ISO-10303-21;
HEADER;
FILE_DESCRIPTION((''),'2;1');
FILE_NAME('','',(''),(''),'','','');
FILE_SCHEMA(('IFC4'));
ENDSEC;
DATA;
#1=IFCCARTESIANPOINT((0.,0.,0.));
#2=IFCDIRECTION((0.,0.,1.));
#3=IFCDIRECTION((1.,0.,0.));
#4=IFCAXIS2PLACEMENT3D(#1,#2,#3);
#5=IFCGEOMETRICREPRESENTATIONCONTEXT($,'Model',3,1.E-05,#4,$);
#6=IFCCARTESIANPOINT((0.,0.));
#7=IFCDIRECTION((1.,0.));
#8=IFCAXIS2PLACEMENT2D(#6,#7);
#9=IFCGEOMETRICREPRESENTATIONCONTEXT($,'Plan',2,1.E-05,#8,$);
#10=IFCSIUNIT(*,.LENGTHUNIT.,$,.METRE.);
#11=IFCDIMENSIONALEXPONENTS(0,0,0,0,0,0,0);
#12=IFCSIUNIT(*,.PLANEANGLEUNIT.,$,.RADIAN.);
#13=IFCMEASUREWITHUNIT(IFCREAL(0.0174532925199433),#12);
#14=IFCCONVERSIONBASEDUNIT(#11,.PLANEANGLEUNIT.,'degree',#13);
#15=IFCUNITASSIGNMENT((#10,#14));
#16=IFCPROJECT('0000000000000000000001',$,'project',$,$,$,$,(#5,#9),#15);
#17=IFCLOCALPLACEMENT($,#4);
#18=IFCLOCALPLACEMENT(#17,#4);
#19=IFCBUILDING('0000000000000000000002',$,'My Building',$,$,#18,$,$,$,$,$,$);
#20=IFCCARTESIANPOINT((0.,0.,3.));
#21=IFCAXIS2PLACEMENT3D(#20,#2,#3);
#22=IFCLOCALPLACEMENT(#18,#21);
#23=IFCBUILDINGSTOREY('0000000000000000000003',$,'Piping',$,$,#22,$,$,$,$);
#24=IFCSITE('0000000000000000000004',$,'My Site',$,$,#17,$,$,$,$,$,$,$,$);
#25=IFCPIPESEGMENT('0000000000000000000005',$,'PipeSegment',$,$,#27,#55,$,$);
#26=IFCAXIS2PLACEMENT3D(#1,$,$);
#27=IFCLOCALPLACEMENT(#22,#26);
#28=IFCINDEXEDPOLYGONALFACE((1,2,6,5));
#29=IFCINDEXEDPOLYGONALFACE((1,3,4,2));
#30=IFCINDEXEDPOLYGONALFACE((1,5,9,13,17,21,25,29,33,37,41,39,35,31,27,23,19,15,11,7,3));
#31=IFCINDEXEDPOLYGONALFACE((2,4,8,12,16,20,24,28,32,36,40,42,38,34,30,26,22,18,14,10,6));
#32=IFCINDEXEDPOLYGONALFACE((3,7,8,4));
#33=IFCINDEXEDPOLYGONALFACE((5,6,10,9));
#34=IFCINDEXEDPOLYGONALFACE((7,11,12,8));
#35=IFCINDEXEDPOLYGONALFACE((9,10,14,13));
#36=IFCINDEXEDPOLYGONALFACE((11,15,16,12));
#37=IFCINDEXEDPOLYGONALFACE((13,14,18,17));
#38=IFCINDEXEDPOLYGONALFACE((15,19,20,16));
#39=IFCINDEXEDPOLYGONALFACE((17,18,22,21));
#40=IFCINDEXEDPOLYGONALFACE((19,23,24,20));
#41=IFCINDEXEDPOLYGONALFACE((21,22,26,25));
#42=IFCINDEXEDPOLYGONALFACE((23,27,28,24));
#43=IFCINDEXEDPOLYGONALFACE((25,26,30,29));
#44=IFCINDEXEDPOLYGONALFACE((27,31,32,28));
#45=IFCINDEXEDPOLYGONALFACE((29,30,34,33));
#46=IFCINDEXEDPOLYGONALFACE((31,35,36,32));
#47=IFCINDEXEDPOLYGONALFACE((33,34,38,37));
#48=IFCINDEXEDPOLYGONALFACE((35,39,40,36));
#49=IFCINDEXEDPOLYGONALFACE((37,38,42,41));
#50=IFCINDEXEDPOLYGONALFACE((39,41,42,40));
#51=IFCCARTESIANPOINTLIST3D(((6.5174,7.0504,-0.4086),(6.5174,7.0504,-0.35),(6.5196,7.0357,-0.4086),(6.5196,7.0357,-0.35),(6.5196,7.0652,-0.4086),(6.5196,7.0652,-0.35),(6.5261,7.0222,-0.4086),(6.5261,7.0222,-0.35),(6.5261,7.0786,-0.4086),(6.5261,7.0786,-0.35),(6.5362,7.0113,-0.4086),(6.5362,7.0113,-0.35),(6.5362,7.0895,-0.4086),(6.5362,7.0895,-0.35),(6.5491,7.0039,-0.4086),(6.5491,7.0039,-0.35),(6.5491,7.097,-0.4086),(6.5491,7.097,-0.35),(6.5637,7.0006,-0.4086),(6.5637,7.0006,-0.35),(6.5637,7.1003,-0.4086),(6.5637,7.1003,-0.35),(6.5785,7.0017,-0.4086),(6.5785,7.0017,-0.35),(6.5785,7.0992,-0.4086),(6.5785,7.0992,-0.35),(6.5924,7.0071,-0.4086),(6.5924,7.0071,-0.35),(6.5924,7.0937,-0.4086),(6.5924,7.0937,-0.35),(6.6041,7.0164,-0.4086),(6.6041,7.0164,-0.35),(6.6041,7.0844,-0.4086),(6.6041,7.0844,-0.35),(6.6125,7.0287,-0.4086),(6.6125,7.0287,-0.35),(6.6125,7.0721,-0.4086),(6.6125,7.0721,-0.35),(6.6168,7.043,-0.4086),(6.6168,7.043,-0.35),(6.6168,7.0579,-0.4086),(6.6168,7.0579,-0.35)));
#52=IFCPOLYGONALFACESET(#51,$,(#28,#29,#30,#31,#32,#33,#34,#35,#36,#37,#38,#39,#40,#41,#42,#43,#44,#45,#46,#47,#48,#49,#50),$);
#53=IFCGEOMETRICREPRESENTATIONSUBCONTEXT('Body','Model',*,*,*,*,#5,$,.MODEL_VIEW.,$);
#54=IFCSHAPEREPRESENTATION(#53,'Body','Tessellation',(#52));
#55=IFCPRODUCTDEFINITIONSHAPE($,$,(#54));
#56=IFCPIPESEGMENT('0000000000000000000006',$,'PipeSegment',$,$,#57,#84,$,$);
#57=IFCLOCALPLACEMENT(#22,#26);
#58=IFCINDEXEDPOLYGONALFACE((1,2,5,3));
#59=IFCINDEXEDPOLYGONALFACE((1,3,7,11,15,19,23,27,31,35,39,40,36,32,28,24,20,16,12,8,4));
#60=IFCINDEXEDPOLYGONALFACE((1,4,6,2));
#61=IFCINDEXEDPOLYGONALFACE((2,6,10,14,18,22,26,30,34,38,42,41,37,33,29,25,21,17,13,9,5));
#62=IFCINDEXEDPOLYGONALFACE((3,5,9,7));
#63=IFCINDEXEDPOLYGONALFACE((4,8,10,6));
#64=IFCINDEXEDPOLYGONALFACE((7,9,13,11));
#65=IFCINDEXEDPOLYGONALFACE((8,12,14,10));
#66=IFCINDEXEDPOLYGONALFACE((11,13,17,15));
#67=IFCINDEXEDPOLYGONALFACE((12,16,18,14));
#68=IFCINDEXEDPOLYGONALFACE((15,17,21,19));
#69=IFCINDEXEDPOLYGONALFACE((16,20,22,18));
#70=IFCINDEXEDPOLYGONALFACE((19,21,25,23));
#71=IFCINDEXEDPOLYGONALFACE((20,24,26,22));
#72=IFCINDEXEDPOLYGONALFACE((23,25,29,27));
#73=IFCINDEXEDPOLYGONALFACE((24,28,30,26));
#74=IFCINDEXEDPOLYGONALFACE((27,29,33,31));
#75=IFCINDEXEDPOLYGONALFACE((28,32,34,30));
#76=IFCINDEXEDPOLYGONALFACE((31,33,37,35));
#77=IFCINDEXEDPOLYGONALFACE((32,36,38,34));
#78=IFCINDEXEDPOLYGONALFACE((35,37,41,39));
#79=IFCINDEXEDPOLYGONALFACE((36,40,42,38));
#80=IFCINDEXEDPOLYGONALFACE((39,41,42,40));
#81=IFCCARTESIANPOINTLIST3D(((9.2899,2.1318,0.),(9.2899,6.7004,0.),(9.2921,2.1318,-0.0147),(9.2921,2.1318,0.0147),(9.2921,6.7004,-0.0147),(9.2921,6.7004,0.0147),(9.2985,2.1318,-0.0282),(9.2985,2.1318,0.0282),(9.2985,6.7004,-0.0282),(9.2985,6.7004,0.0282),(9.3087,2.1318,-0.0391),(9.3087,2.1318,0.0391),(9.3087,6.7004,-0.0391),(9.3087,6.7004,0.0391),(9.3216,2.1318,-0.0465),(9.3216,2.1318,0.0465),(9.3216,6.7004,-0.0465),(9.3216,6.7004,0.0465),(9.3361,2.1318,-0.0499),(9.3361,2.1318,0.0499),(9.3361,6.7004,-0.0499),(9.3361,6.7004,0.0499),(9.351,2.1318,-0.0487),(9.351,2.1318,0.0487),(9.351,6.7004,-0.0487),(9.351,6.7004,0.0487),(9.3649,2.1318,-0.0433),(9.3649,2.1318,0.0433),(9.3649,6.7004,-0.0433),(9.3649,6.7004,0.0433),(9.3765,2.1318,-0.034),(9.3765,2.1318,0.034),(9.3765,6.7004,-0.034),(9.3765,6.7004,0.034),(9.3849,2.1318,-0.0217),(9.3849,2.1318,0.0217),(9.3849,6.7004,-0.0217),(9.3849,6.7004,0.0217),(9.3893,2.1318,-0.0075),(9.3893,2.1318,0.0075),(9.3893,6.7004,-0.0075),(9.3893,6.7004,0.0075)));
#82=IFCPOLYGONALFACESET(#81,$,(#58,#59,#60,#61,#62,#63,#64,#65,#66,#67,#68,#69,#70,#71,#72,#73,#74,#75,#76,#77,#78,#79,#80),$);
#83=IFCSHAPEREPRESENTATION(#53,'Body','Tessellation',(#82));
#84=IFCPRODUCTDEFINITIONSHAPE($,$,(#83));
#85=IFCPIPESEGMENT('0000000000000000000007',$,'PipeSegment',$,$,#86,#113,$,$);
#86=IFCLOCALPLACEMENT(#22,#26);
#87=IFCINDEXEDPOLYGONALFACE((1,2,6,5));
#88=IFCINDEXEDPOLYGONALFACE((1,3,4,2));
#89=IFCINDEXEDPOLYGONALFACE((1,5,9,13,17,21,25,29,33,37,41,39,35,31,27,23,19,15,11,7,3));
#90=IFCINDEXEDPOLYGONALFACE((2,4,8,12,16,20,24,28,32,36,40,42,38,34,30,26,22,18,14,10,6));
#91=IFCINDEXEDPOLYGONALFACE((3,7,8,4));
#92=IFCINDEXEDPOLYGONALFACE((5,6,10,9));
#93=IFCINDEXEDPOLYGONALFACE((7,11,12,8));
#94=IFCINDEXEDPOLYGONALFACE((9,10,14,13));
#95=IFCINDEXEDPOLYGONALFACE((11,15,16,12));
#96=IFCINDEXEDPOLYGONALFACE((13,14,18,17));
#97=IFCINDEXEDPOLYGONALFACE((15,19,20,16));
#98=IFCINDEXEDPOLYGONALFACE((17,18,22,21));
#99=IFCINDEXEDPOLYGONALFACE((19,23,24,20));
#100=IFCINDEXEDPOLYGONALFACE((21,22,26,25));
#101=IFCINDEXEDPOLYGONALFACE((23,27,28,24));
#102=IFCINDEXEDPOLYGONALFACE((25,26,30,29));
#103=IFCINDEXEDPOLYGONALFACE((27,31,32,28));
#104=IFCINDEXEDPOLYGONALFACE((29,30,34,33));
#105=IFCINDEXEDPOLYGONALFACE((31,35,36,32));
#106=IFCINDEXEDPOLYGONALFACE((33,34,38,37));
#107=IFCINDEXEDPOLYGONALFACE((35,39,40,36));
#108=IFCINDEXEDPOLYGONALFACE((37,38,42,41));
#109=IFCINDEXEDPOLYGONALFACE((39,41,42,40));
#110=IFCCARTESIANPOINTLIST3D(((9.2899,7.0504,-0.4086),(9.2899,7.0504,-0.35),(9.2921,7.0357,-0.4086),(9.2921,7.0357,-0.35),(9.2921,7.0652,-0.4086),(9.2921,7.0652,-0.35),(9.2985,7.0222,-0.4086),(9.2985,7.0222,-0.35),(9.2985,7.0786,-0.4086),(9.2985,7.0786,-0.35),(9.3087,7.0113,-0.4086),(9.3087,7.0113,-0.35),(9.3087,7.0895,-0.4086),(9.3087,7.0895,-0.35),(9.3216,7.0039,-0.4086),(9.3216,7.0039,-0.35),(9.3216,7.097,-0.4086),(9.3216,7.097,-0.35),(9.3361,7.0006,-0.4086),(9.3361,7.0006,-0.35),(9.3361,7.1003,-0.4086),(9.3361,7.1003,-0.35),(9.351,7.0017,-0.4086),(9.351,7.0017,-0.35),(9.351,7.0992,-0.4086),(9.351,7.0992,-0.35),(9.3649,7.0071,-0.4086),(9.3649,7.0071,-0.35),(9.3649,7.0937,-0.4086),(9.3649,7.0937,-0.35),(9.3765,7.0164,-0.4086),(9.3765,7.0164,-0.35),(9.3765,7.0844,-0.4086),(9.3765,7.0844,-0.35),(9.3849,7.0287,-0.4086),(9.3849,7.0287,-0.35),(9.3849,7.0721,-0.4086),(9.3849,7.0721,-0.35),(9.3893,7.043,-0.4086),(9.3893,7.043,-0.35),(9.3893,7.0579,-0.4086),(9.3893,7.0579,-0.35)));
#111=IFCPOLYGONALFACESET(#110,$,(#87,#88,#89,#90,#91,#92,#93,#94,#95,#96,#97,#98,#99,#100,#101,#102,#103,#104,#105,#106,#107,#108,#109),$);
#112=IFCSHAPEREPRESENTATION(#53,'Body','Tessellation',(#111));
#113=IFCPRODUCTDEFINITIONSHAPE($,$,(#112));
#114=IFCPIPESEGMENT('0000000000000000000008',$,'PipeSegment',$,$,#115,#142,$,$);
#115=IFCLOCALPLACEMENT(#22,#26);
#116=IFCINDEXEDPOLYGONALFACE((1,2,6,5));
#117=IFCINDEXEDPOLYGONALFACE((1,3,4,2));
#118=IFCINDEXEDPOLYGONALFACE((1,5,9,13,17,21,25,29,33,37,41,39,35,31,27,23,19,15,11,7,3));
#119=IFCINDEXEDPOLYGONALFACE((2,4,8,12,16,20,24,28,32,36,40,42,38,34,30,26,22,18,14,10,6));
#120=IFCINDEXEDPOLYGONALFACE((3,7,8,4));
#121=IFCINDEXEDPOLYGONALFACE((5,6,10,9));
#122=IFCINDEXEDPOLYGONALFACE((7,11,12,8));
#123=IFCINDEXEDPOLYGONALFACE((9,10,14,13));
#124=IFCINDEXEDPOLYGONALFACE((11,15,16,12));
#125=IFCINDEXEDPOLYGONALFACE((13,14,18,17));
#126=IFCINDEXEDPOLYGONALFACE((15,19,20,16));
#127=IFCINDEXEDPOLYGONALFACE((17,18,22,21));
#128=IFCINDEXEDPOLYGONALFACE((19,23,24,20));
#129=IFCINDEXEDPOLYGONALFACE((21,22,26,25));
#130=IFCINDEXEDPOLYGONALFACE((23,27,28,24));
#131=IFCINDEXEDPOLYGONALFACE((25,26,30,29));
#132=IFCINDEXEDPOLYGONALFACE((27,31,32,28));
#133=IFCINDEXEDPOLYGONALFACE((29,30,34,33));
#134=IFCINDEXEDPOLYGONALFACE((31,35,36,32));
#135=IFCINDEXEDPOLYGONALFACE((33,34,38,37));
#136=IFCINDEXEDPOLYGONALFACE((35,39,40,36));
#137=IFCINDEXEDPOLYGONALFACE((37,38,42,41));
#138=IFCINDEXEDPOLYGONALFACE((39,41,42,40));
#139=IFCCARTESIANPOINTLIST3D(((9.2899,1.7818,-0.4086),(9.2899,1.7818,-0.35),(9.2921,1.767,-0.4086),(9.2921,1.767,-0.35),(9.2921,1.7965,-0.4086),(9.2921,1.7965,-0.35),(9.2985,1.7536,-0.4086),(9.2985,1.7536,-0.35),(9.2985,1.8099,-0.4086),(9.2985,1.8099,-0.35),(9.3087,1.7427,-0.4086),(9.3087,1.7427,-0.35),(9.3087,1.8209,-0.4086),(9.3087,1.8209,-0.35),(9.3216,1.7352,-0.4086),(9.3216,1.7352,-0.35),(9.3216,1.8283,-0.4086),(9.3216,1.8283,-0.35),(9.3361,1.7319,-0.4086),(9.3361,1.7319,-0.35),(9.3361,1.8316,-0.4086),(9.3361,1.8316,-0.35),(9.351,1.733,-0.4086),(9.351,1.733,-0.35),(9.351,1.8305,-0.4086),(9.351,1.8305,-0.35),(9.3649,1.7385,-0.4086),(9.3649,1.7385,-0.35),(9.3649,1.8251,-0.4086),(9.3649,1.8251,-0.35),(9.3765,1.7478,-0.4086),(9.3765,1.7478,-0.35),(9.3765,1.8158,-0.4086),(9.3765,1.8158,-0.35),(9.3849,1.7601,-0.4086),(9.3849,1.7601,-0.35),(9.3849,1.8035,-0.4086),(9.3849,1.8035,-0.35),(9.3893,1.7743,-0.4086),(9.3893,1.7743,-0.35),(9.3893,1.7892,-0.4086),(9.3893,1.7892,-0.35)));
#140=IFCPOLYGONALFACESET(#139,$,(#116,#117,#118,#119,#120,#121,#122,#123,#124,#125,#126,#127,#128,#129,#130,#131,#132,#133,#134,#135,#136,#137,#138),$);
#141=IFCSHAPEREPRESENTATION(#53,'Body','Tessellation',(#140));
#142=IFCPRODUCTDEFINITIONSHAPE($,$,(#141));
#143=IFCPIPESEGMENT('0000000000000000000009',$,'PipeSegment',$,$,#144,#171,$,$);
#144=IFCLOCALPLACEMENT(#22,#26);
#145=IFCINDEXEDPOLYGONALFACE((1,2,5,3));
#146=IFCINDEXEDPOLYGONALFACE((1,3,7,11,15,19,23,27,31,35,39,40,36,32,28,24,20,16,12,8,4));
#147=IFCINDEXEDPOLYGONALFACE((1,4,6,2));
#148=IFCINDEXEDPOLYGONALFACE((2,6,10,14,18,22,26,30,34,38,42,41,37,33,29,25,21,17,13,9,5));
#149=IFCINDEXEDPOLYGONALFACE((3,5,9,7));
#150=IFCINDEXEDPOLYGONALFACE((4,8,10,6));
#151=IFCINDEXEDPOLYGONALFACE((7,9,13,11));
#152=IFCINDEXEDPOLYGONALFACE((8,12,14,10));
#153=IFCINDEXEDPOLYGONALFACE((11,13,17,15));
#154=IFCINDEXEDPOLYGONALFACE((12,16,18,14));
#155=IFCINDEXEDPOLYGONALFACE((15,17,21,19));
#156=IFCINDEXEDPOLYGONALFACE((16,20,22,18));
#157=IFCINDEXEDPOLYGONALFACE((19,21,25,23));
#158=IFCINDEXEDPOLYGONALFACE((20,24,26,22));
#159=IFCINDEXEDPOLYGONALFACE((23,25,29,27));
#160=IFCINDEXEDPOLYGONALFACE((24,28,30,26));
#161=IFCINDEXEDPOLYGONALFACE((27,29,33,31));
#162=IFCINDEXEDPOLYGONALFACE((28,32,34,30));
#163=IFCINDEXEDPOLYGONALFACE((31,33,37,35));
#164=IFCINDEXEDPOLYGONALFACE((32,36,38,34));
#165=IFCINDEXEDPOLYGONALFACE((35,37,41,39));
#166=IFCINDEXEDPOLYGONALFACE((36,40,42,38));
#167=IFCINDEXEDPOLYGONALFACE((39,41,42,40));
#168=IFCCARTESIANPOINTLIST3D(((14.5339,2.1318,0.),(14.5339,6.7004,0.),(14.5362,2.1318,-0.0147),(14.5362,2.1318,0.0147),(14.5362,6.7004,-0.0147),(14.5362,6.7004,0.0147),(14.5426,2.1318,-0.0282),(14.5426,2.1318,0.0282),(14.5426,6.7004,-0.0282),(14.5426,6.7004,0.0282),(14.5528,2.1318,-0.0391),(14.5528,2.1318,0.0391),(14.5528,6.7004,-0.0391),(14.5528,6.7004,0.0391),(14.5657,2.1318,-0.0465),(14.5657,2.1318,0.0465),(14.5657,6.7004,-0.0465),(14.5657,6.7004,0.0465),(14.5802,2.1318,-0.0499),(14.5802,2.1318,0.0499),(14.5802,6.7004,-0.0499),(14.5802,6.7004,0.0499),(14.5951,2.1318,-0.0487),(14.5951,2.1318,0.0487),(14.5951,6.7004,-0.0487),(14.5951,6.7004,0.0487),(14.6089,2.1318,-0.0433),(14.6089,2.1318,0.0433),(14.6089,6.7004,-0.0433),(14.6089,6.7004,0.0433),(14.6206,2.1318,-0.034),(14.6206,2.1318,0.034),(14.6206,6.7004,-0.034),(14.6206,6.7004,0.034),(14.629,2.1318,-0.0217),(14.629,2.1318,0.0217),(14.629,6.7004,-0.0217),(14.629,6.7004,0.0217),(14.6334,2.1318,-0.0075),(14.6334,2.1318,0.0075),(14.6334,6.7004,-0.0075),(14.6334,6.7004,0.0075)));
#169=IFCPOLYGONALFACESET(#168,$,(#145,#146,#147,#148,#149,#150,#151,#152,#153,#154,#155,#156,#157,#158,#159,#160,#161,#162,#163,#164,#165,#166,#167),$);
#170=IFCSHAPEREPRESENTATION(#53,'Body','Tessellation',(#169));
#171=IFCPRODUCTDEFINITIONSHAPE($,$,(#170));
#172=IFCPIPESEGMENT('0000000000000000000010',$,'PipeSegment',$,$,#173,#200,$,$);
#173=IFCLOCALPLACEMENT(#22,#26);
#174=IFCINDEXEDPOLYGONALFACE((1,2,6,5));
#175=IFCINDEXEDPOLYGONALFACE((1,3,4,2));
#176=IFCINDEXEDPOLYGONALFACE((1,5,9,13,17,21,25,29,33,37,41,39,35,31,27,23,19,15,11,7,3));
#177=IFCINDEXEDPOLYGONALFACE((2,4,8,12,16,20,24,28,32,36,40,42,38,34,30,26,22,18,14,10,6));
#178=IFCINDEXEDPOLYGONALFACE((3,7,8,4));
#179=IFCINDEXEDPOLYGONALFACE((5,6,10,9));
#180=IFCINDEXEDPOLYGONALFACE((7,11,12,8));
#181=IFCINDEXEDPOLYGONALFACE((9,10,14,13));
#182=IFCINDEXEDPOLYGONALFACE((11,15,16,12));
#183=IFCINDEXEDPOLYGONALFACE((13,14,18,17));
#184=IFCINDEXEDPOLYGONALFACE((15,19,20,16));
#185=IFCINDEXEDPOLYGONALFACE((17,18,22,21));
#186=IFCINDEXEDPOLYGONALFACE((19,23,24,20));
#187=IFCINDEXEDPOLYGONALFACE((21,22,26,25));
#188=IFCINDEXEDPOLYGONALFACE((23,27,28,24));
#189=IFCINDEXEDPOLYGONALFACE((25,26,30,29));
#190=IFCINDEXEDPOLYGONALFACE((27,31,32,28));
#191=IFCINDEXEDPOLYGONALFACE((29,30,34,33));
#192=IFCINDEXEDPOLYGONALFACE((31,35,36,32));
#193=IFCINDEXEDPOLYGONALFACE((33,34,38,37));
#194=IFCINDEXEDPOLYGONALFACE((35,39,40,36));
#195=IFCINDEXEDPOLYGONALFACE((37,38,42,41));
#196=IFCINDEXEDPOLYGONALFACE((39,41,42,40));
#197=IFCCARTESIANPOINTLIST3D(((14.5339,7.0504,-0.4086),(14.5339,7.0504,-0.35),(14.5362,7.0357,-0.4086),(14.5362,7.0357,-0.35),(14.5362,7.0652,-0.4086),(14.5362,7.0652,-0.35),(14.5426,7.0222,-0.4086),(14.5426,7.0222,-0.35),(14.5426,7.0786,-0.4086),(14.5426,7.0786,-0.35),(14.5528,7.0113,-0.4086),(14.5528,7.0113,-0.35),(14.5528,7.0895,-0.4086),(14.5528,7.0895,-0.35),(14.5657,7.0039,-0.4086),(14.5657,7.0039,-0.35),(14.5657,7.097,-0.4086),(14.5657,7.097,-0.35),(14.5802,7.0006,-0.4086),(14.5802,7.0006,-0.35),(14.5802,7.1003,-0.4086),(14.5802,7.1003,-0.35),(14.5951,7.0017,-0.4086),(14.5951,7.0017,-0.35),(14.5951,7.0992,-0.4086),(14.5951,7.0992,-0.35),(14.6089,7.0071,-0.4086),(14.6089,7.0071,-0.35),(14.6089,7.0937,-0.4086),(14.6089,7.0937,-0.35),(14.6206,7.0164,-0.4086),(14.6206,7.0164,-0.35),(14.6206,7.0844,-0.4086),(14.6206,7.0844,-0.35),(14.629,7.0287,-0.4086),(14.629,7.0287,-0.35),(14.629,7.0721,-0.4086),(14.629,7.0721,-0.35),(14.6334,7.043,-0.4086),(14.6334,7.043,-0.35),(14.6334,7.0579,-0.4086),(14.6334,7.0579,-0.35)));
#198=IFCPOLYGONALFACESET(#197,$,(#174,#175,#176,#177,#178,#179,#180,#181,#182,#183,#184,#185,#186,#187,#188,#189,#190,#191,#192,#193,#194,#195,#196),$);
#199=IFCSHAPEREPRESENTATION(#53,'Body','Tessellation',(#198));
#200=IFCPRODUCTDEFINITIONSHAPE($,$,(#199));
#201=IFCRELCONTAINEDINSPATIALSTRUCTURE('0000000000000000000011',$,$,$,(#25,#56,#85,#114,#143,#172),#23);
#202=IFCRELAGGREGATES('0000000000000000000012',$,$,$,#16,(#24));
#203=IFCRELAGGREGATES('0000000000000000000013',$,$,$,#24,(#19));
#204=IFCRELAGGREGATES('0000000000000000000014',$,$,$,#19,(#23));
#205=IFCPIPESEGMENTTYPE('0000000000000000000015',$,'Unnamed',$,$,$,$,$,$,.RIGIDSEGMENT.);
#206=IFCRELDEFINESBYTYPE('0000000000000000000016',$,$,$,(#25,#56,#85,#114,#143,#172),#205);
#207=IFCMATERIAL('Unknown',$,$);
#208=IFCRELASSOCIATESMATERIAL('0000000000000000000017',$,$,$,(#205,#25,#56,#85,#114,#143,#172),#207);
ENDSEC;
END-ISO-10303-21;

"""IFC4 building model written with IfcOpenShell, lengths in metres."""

from ifc_helpers import new_model, entity, si_unit, converted_unit, frame, origin_with_axes, origin_2d_with_axis, place, context, subcontext, project, spatial, circle, extrude, material, material_profile, profile_set, profile_usage, type_object, element, save


model = new_model("IFC4")

# Units and contexts
model_context = context("Model", 3, precision=1e-05, world=origin_with_axes())
plan_context = context("Plan", 2, precision=1e-05, world=origin_2d_with_axis())
body_context = subcontext(model_context, "Body", "Model", "MODEL_VIEW")
ifc_project = project(units=[si_unit("LENGTHUNIT", "METRE"), converted_unit("PLANEANGLEUNIT", "degree", entity("IfcReal", 0.0174532925199433), si_unit("PLANEANGLEUNIT", "RADIAN"), dimensions=[0, 0, 0, 0, 0, 0, 0])], contexts=[model_context, plan_context])

# Site, building, storey
site_placement = place(None, origin_with_axes())
site = spatial("IfcSite", under=ifc_project, at=site_placement, Name="My Site")
building_placement = place(site_placement, origin_with_axes())
building = spatial("IfcBuilding", under=site, at=building_placement, Name="My Building")
storey_placement = place(building_placement, frame((0.0, 0.0, 3.0), z_axis=(0.0, 0.0, 1.0), x_axis=(1.0, 0.0, 0.0)))
storey = spatial("IfcBuildingStorey", under=building, at=storey_placement, Name="Piping")

# Pipe segments
ifc_material = material(Name="Unknown")
ifc_material_profile = material_profile(ifc_material, circle(Radius=0.05))
ifc_profile_set = profile_set([ifc_material_profile])
pipe_segment_type = type_object("IfcPipeSegmentType", Name="Unnamed", PredefinedType="RIGIDSEGMENT", material=ifc_profile_set)
ifc_profile_usage_1 = profile_usage(ifc_profile_set, cardinal=5)
pipe_segment_1_placement = place(storey_placement, frame((6.5674, 7.0504, -0.35), z_axis=(0.0, 0.0, -1.0), x_axis=(-1.0, 0.0, 0.0)))
element("IfcPipeSegment", 1, at=pipe_segment_1_placement, inside=storey, type_object=pipe_segment_type, material=ifc_profile_usage_1, Name="PipeSegment", context=body_context, shape_type="SweptSolid", body=[
    extrude(circle(Radius=0.05), origin_with_axes(), (0.0, 0.0, 1.0), 0.0586),
])
ifc_profile_usage_2 = profile_usage(ifc_profile_set, cardinal=5)
pipe_segment_2_placement = place(storey_placement, frame((9.3399, 2.1318, 0.0), z_axis=(0.0, 1.0, 0.0), x_axis=(-1.0, 0.0, 0.0)))
element("IfcPipeSegment", 2, at=pipe_segment_2_placement, inside=storey, type_object=pipe_segment_type, material=ifc_profile_usage_2, Name="PipeSegment", context=body_context, shape_type="SweptSolid", body=[
    extrude(circle(Radius=0.05), origin_with_axes(), (0.0, 0.0, 1.0), 4.5686),
])
ifc_profile_usage_3 = profile_usage(ifc_profile_set, cardinal=5)
pipe_segment_3_placement = place(storey_placement, frame((9.3399, 7.0504, -0.35), z_axis=(0.0, 0.0, -1.0), x_axis=(-1.0, 0.0, 0.0)))
element("IfcPipeSegment", 3, at=pipe_segment_3_placement, inside=storey, type_object=pipe_segment_type, material=ifc_profile_usage_3, Name="PipeSegment", context=body_context, shape_type="SweptSolid", body=[
    extrude(circle(Radius=0.05), origin_with_axes(), (0.0, 0.0, 1.0), 0.0586),
])
ifc_profile_usage_4 = profile_usage(ifc_profile_set, cardinal=5)
pipe_segment_4_placement = place(storey_placement, frame((9.3399, 1.7818, -0.35), z_axis=(0.0, 0.0, -1.0), x_axis=(-1.0, 0.0, 0.0)))
element("IfcPipeSegment", 4, at=pipe_segment_4_placement, inside=storey, type_object=pipe_segment_type, material=ifc_profile_usage_4, Name="PipeSegment", context=body_context, shape_type="SweptSolid", body=[
    extrude(circle(Radius=0.05), origin_with_axes(), (0.0, 0.0, 1.0), 0.0586),
])
ifc_profile_usage_5 = profile_usage(ifc_profile_set, cardinal=5)
pipe_segment_5_placement = place(storey_placement, frame((14.5839, 2.1318, 0.0), z_axis=(0.0, 1.0, 0.0), x_axis=(-1.0, 0.0, 0.0)))
element("IfcPipeSegment", 5, at=pipe_segment_5_placement, inside=storey, type_object=pipe_segment_type, material=ifc_profile_usage_5, Name="PipeSegment", context=body_context, shape_type="SweptSolid", body=[
    extrude(circle(Radius=0.05), origin_with_axes(), (0.0, 0.0, 1.0), 4.5686),
])
ifc_profile_usage_6 = profile_usage(ifc_profile_set, cardinal=5)
pipe_segment_6_placement = place(storey_placement, frame((14.5839, 7.0504, -0.35), z_axis=(0.0, 0.0, -1.0), x_axis=(-1.0, 0.0, 0.0)))
element("IfcPipeSegment", 6, at=pipe_segment_6_placement, inside=storey, type_object=pipe_segment_type, material=ifc_profile_usage_6, Name="PipeSegment", context=body_context, shape_type="SweptSolid", body=[
    extrude(circle(Radius=0.05), origin_with_axes(), (0.0, 0.0, 1.0), 0.0586),
])

save(model, "model.ifc")
